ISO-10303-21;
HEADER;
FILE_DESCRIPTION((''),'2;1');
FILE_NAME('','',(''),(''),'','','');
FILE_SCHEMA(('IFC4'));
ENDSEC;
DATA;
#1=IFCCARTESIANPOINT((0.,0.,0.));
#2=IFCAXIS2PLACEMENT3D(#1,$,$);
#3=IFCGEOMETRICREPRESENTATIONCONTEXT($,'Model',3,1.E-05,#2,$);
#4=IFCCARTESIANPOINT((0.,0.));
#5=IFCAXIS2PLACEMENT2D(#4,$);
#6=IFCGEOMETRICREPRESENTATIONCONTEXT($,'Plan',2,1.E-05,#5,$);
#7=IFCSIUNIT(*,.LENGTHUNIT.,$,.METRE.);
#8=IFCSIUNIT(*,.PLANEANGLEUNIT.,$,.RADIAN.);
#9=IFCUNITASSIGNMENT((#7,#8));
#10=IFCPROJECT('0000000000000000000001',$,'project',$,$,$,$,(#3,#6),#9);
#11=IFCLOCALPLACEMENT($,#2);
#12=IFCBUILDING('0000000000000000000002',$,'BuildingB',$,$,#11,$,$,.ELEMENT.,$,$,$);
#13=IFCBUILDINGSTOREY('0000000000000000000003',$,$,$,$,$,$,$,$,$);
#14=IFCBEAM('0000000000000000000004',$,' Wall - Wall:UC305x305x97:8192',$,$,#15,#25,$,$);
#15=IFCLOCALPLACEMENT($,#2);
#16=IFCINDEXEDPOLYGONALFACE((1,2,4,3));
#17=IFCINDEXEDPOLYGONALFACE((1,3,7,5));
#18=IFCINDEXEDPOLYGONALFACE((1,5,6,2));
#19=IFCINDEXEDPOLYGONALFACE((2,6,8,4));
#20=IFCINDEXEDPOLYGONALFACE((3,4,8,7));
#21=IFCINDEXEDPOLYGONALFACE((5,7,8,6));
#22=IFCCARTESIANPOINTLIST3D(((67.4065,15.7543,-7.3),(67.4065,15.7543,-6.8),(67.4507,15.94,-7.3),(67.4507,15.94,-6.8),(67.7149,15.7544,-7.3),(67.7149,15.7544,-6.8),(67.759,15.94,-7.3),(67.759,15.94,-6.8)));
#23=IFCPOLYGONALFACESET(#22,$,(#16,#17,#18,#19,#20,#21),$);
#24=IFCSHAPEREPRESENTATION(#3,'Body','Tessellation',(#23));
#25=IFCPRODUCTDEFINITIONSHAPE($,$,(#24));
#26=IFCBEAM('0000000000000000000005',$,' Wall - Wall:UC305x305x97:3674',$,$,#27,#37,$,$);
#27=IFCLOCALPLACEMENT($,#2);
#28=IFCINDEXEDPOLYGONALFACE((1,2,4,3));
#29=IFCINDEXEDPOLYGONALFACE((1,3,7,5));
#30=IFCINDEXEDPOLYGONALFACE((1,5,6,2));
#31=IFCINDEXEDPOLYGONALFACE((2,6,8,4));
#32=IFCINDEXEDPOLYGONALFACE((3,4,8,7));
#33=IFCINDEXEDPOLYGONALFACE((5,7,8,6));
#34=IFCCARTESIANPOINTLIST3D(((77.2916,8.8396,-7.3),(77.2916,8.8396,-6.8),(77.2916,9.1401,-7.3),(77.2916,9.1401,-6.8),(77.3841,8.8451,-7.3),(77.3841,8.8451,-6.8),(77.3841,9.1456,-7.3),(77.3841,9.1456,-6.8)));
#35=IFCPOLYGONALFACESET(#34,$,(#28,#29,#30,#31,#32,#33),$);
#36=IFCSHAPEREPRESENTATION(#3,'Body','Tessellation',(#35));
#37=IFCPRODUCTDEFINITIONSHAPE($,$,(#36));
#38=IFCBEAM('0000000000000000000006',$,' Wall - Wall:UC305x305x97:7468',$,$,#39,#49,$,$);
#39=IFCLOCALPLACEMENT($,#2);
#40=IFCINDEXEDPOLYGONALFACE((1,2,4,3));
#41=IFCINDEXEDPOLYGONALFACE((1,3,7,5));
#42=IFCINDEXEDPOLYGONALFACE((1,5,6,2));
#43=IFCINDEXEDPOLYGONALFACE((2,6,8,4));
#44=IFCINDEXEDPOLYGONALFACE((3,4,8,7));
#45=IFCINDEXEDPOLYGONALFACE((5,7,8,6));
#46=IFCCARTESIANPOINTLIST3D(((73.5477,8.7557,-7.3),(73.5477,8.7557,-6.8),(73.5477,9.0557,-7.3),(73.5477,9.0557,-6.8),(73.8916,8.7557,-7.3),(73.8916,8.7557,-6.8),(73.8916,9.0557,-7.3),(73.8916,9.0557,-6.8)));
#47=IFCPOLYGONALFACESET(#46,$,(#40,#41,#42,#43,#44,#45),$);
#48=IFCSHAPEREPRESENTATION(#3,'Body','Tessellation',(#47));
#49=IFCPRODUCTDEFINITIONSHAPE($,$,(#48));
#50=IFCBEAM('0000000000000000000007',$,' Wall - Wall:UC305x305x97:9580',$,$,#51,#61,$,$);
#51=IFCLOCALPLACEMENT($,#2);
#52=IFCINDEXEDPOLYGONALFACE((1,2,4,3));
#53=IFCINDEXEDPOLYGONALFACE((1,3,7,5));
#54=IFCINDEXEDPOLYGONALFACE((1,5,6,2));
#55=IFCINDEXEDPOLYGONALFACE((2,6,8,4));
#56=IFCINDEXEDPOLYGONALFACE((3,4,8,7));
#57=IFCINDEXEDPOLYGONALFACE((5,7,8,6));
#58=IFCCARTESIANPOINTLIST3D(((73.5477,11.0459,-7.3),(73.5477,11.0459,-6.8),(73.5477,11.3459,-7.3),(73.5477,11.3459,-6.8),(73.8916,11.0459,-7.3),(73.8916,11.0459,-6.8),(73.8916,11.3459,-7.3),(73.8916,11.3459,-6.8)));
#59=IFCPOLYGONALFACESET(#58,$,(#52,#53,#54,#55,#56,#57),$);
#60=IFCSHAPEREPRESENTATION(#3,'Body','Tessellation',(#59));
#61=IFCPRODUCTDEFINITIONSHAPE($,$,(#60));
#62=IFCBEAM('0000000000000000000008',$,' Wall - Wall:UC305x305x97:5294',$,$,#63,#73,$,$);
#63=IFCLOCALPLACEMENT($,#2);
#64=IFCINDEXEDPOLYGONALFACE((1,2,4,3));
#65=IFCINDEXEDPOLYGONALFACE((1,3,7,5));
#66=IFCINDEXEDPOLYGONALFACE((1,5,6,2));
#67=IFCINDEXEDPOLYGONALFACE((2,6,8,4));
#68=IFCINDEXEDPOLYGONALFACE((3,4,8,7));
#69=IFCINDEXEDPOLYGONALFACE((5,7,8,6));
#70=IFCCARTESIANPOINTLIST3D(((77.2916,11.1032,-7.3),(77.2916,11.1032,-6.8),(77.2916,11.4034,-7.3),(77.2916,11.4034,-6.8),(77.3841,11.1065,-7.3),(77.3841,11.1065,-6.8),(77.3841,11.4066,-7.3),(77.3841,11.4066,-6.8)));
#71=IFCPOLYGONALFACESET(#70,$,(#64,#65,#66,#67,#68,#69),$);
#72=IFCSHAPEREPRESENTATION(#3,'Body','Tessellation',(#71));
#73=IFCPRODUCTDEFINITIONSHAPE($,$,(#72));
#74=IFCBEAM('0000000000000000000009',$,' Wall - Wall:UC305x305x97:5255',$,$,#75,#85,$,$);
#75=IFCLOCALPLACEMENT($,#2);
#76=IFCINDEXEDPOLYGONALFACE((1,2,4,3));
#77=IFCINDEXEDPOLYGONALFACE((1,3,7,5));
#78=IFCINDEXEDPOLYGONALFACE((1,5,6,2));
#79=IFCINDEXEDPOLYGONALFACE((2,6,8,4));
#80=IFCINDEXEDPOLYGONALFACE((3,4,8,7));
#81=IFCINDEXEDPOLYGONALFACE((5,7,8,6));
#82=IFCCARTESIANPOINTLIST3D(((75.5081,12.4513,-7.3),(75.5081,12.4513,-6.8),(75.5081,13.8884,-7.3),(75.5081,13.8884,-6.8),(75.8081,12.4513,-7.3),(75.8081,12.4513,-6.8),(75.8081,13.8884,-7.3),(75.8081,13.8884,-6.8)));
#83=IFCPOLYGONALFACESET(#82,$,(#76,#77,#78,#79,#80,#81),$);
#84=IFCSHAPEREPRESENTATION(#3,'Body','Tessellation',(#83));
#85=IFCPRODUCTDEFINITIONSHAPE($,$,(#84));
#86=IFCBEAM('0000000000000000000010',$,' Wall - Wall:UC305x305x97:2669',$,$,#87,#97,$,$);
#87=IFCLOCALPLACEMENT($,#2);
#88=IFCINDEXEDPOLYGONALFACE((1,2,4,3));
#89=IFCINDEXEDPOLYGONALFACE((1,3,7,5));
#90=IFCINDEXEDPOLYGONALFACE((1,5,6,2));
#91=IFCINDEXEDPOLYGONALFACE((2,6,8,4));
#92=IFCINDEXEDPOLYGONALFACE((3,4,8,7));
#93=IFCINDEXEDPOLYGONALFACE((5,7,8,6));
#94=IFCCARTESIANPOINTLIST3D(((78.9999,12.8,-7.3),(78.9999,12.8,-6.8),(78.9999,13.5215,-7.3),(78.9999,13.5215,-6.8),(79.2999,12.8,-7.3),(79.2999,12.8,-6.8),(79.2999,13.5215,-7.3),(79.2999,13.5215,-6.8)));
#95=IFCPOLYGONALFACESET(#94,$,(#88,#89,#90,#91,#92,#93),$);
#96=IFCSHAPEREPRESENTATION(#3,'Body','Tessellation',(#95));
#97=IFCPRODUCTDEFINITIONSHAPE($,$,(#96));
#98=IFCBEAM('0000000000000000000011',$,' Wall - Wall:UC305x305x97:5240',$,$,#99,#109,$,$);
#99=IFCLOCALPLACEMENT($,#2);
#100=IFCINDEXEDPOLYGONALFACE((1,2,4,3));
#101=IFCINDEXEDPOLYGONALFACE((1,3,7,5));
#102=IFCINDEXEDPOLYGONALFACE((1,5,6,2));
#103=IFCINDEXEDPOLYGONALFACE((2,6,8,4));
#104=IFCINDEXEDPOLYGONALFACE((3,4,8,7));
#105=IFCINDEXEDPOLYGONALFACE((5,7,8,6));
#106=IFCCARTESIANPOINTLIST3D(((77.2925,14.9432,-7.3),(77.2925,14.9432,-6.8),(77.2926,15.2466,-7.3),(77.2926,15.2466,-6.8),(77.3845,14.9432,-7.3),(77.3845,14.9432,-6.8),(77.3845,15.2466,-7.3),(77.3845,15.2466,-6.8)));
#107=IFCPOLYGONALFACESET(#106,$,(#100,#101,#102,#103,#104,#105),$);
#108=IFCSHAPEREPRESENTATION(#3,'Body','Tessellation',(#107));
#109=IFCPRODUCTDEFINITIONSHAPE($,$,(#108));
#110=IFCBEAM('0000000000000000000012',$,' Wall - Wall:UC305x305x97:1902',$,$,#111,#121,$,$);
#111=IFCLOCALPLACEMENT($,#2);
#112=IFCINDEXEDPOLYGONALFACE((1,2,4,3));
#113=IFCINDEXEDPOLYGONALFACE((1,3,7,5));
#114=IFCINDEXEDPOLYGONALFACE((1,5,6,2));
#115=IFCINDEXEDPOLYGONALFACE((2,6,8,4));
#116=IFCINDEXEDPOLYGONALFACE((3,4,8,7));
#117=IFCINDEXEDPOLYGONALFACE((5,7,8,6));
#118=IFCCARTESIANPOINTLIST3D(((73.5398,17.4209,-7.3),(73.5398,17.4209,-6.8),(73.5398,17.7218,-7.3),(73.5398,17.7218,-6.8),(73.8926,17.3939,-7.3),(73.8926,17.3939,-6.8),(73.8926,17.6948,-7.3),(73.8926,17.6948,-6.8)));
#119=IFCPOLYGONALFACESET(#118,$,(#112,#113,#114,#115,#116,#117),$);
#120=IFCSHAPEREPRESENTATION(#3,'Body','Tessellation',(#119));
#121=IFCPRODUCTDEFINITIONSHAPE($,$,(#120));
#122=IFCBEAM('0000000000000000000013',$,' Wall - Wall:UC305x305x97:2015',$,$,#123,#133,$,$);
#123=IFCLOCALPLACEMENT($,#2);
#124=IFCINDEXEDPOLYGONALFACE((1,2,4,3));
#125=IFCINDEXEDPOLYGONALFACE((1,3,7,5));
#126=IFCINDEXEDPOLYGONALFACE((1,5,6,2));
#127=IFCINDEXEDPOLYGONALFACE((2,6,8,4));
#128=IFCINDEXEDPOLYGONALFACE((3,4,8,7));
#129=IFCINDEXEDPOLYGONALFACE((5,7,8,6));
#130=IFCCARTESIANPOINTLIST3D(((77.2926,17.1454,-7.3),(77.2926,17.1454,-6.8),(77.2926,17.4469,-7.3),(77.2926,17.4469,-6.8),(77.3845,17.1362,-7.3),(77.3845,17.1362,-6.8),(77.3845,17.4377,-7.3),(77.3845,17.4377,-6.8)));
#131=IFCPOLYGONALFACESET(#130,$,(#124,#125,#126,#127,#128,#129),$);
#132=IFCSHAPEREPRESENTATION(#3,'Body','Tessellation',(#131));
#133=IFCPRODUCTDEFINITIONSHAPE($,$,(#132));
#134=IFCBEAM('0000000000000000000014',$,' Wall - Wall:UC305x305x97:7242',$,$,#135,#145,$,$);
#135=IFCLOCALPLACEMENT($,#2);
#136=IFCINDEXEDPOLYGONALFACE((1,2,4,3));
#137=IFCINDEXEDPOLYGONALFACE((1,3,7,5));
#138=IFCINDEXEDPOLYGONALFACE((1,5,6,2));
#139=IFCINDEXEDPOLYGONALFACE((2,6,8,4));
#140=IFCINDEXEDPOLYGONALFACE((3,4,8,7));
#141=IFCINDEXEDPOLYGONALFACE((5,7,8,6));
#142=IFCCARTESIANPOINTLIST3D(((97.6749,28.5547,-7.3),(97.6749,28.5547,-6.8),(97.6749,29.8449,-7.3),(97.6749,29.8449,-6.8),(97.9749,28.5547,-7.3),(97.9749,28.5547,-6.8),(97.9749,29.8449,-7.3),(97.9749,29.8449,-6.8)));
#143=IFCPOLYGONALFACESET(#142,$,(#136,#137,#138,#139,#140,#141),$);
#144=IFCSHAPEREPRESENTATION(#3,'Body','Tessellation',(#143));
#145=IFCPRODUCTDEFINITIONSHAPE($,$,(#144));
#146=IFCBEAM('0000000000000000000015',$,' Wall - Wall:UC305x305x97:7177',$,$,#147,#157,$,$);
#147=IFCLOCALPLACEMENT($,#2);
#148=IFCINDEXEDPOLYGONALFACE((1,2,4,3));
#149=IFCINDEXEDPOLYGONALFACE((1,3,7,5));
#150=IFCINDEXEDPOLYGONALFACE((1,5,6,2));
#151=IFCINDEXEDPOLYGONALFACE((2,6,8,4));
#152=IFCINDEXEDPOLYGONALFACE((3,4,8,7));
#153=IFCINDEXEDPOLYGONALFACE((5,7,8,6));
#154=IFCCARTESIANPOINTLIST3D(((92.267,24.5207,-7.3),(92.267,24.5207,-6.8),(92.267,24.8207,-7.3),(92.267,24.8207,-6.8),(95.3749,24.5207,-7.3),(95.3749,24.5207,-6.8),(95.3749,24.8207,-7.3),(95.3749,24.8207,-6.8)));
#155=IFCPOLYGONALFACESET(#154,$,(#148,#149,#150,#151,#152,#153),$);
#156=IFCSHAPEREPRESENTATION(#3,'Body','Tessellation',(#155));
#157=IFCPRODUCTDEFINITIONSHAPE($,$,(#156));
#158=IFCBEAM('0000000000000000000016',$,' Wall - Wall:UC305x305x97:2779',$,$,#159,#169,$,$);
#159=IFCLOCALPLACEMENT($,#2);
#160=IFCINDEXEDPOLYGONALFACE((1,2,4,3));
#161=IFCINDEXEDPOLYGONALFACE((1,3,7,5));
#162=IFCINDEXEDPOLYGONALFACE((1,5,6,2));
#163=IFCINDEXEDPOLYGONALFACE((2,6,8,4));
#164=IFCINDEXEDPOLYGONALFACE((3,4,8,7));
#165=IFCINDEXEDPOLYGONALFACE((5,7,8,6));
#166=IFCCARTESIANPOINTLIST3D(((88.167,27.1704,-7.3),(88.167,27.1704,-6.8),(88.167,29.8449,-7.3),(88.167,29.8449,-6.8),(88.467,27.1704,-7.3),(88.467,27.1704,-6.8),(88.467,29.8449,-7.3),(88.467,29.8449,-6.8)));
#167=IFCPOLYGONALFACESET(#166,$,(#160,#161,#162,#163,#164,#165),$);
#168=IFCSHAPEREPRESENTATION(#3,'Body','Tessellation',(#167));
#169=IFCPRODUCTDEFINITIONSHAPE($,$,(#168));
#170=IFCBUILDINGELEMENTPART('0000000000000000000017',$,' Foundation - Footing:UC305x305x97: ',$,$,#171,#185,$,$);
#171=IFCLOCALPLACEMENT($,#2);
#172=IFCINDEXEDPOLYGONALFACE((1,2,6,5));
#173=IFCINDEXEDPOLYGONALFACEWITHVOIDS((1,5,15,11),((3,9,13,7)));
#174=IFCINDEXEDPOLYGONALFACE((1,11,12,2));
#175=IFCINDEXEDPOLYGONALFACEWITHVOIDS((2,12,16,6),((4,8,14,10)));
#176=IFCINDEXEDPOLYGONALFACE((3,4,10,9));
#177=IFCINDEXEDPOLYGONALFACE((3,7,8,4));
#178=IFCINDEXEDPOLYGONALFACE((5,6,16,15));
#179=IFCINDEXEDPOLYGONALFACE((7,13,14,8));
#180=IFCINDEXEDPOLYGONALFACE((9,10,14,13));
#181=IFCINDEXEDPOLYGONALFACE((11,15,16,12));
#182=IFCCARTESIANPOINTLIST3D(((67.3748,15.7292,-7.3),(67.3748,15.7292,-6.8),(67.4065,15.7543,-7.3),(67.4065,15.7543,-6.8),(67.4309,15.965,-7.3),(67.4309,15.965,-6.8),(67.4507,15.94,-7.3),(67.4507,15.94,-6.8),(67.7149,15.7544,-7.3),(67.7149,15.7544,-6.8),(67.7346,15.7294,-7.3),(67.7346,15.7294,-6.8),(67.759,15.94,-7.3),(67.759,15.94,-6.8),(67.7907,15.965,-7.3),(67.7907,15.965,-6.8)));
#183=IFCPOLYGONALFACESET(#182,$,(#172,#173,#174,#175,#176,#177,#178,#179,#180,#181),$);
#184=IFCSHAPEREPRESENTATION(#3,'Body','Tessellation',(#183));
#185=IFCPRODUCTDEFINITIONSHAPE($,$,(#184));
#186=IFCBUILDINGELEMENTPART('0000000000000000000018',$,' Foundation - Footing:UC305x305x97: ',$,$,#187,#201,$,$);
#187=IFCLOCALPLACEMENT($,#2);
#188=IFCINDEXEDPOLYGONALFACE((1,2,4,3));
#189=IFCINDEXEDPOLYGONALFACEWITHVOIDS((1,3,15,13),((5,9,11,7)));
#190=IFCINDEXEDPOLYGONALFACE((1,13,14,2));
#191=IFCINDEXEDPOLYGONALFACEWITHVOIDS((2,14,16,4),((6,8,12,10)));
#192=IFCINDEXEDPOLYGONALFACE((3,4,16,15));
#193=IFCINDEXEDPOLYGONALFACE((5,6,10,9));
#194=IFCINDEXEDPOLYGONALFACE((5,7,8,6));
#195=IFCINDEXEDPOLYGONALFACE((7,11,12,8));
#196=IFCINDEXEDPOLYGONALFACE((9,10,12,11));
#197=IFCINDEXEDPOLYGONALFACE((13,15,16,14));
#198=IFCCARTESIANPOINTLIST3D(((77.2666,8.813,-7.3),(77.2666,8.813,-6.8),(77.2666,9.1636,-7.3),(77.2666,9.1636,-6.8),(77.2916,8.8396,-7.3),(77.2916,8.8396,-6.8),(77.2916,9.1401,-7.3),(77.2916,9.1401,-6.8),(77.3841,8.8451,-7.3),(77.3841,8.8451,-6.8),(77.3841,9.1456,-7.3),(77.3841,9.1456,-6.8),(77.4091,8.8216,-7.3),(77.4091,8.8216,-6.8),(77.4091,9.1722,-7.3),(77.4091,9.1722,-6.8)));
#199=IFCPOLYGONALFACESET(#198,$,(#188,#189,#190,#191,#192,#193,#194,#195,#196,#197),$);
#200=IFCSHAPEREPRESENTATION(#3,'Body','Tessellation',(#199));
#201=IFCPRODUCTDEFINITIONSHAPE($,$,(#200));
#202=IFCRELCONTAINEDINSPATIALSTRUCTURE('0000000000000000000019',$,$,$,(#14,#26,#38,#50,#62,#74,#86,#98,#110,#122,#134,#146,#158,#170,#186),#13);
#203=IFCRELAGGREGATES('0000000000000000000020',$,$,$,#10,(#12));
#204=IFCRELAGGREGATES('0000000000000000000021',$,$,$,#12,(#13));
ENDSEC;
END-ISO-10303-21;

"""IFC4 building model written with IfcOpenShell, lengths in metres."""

from ifc_helpers import new_model, si_unit, origin, origin_2d, place, context, project, spatial, polyline, outline, extrude, element, save


model = new_model("IFC4")

# Units and contexts
model_context = context("Model", 3, precision=1e-05, world=origin())
plan_context = context("Plan", 2, precision=1e-05, world=origin_2d())
ifc_project = project(units=[si_unit("LENGTHUNIT", "METRE"), si_unit("PLANEANGLEUNIT", "RADIAN")], contexts=[model_context, plan_context])

# Building, storey
building_placement = place(None, origin())
building = spatial("IfcBuilding", under=ifc_project, at=building_placement, Name="BuildingB", CompositionType="ELEMENT")
storey = spatial("IfcBuildingStorey", under=building)

# Beams
element("IfcBeam", 1, inside=storey, Name=" Wall - Wall:UC305x305x97:8192", context=model_context, shape_type="SweptSolid", body=[
    extrude(outline(polyline([(67.7149, 15.7544, -7.3), (67.759, 15.94, -7.3), (67.4507, 15.94, -7.3), (67.4065, 15.7543, -7.3), (67.7149, 15.7544, -7.3)])), None, (0.0, 0.0, 1.0), 0.5),
])
element("IfcBeam", 2, inside=storey, Name=" Wall - Wall:UC305x305x97:3674", context=model_context, shape_type="SweptSolid", body=[
    extrude(outline(polyline([(77.3841, 8.8451, -7.3), (77.2916, 8.8396, -7.3), (77.2916, 9.1401, -7.3), (77.3841, 9.1456, -7.3), (77.3841, 8.8451, -7.3)])), None, (0.0, 0.0, 1.0), 0.5),
])
element("IfcBeam", 3, inside=storey, Name=" Wall - Wall:UC305x305x97:7468", context=model_context, shape_type="SweptSolid", body=[
    extrude(outline(polyline([(73.8916, 8.7557, -7.3), (73.5477, 8.7557, -7.3), (73.5477, 9.0557, -7.3), (73.8916, 9.0557, -7.3), (73.8916, 8.7557, -7.3)])), None, (0.0, 0.0, 1.0), 0.5),
])
element("IfcBeam", 4, inside=storey, Name=" Wall - Wall:UC305x305x97:9580", context=model_context, shape_type="SweptSolid", body=[
    extrude(outline(polyline([(73.8916, 11.0459, -7.3), (73.5477, 11.0459, -7.3), (73.5477, 11.3459, -7.3), (73.8916, 11.3459, -7.3), (73.8916, 11.0459, -7.3)])), None, (0.0, 0.0, 1.0), 0.5),
])
element("IfcBeam", 5, inside=storey, Name=" Wall - Wall:UC305x305x97:5294", context=model_context, shape_type="SweptSolid", body=[
    extrude(outline(polyline([(77.3841, 11.1065, -7.3), (77.2916, 11.1032, -7.3), (77.2916, 11.4034, -7.3), (77.3841, 11.4066, -7.3), (77.3841, 11.1065, -7.3)])), None, (0.0, 0.0, 1.0), 0.5),
])
element("IfcBeam", 6, inside=storey, Name=" Wall - Wall:UC305x305x97:5255", context=model_context, shape_type="SweptSolid", body=[
    extrude(outline(polyline([(75.8081, 12.4513, -7.3), (75.5081, 12.4513, -7.3), (75.5081, 13.8884, -7.3), (75.8081, 13.8884, -7.3), (75.8081, 12.4513, -7.3)])), None, (0.0, 0.0, 1.0), 0.5),
])
element("IfcBeam", 7, inside=storey, Name=" Wall - Wall:UC305x305x97:2669", context=model_context, shape_type="SweptSolid", body=[
    extrude(outline(polyline([(79.2999, 12.8, -7.3), (78.9999, 12.8, -7.3), (78.9999, 13.5215, -7.3), (79.2999, 13.5215, -7.3), (79.2999, 12.8, -7.3)])), None, (0.0, 0.0, 1.0), 0.5),
])
element("IfcBeam", 8, inside=storey, Name=" Wall - Wall:UC305x305x97:5240", context=model_context, shape_type="SweptSolid", body=[
    extrude(outline(polyline([(77.3845, 14.9432, -7.3), (77.2925, 14.9432, -7.3), (77.2926, 15.2466, -7.3), (77.3845, 15.2466, -7.3), (77.3845, 14.9432, -7.3)])), None, (0.0, 0.0, 1.0), 0.5),
])
element("IfcBeam", 9, inside=storey, Name=" Wall - Wall:UC305x305x97:1902", context=model_context, shape_type="SweptSolid", body=[
    extrude(outline(polyline([(73.8926, 17.3939, -7.3), (73.5398, 17.4209, -7.3), (73.5398, 17.7218, -7.3), (73.8926, 17.6948, -7.3), (73.8926, 17.3939, -7.3)])), None, (0.0, 0.0, 1.0), 0.5),
])
element("IfcBeam", 10, inside=storey, Name=" Wall - Wall:UC305x305x97:2015", context=model_context, shape_type="SweptSolid", body=[
    extrude(outline(polyline([(77.3845, 17.1362, -7.3), (77.2926, 17.1454, -7.3), (77.2926, 17.4469, -7.3), (77.3845, 17.4377, -7.3), (77.3845, 17.1362, -7.3)])), None, (0.0, 0.0, 1.0), 0.5),
])
element("IfcBeam", 11, inside=storey, Name=" Wall - Wall:UC305x305x97:7242", context=model_context, shape_type="SweptSolid", body=[
    extrude(outline(polyline([(97.9749, 28.5547, -7.3), (97.6749, 28.5547, -7.3), (97.6749, 29.8449, -7.3), (97.9749, 29.8449, -7.3), (97.9749, 28.5547, -7.3)])), None, (0.0, 0.0, 1.0), 0.5),
])
element("IfcBeam", 12, inside=storey, Name=" Wall - Wall:UC305x305x97:7177", context=model_context, shape_type="SweptSolid", body=[
    extrude(outline(polyline([(95.3749, 24.5207, -7.3), (95.3749, 24.8207, -7.3), (92.267, 24.8207, -7.3), (92.267, 24.5207, -7.3), (95.3749, 24.5207, -7.3)])), None, (0.0, 0.0, 1.0), 0.5),
])
element("IfcBeam", 13, inside=storey, Name=" Wall - Wall:UC305x305x97:2779", context=model_context, shape_type="SweptSolid", body=[
    extrude(outline(polyline([(88.467, 27.1704, -7.3), (88.167, 27.1704, -7.3), (88.167, 29.8449, -7.3), (88.467, 29.8449, -7.3), (88.467, 27.1704, -7.3)])), None, (0.0, 0.0, 1.0), 0.5),
])

# Building element parts, openings
building_element_part_1 = element("IfcBuildingElementPart", 14, inside=storey, Name=" Foundation - Footing:UC305x305x97: ", context=model_context, shape_type="SweptSolid", body=[
    extrude(outline(polyline([(67.7346, 15.7294, -7.3), (67.7907, 15.965, -7.3), (67.4309, 15.965, -7.3), (67.3748, 15.7292, -7.3), (67.7346, 15.7294, -7.3)])), None, (0.0, 0.0, 1.0), 0.5),
])
element("IfcOpeningElement", 15, inside=storey, cuts=building_element_part_1, context=model_context, shape_type="SweptSolid", body=[
    extrude(outline(polyline([(67.7149, 15.7544, -7.3), (67.759, 15.94, -7.3), (67.4507, 15.94, -7.3), (67.4065, 15.7543, -7.3), (67.7149, 15.7544, -7.3)])), None, (0.0, 0.0, 1.0), 0.5),
])
building_element_part_2 = element("IfcBuildingElementPart", 16, inside=storey, Name=" Foundation - Footing:UC305x305x97: ", context=model_context, shape_type="SweptSolid", body=[
    extrude(outline(polyline([(77.4091, 8.8216, -7.3), (77.2666, 8.813, -7.3), (77.2666, 9.1636, -7.3), (77.4091, 9.1722, -7.3), (77.4091, 8.8216, -7.3)])), None, (0.0, 0.0, 1.0), 0.5),
])
element("IfcOpeningElement", 17, inside=storey, cuts=building_element_part_2, context=model_context, shape_type="SweptSolid", body=[
    extrude(outline(polyline([(77.3841, 8.8451, -7.3), (77.2916, 8.8396, -7.3), (77.2916, 9.1401, -7.3), (77.3841, 9.1456, -7.3), (77.3841, 8.8451, -7.3)])), None, (0.0, 0.0, 1.0), 0.5),
])

save(model, "model.ifc")
